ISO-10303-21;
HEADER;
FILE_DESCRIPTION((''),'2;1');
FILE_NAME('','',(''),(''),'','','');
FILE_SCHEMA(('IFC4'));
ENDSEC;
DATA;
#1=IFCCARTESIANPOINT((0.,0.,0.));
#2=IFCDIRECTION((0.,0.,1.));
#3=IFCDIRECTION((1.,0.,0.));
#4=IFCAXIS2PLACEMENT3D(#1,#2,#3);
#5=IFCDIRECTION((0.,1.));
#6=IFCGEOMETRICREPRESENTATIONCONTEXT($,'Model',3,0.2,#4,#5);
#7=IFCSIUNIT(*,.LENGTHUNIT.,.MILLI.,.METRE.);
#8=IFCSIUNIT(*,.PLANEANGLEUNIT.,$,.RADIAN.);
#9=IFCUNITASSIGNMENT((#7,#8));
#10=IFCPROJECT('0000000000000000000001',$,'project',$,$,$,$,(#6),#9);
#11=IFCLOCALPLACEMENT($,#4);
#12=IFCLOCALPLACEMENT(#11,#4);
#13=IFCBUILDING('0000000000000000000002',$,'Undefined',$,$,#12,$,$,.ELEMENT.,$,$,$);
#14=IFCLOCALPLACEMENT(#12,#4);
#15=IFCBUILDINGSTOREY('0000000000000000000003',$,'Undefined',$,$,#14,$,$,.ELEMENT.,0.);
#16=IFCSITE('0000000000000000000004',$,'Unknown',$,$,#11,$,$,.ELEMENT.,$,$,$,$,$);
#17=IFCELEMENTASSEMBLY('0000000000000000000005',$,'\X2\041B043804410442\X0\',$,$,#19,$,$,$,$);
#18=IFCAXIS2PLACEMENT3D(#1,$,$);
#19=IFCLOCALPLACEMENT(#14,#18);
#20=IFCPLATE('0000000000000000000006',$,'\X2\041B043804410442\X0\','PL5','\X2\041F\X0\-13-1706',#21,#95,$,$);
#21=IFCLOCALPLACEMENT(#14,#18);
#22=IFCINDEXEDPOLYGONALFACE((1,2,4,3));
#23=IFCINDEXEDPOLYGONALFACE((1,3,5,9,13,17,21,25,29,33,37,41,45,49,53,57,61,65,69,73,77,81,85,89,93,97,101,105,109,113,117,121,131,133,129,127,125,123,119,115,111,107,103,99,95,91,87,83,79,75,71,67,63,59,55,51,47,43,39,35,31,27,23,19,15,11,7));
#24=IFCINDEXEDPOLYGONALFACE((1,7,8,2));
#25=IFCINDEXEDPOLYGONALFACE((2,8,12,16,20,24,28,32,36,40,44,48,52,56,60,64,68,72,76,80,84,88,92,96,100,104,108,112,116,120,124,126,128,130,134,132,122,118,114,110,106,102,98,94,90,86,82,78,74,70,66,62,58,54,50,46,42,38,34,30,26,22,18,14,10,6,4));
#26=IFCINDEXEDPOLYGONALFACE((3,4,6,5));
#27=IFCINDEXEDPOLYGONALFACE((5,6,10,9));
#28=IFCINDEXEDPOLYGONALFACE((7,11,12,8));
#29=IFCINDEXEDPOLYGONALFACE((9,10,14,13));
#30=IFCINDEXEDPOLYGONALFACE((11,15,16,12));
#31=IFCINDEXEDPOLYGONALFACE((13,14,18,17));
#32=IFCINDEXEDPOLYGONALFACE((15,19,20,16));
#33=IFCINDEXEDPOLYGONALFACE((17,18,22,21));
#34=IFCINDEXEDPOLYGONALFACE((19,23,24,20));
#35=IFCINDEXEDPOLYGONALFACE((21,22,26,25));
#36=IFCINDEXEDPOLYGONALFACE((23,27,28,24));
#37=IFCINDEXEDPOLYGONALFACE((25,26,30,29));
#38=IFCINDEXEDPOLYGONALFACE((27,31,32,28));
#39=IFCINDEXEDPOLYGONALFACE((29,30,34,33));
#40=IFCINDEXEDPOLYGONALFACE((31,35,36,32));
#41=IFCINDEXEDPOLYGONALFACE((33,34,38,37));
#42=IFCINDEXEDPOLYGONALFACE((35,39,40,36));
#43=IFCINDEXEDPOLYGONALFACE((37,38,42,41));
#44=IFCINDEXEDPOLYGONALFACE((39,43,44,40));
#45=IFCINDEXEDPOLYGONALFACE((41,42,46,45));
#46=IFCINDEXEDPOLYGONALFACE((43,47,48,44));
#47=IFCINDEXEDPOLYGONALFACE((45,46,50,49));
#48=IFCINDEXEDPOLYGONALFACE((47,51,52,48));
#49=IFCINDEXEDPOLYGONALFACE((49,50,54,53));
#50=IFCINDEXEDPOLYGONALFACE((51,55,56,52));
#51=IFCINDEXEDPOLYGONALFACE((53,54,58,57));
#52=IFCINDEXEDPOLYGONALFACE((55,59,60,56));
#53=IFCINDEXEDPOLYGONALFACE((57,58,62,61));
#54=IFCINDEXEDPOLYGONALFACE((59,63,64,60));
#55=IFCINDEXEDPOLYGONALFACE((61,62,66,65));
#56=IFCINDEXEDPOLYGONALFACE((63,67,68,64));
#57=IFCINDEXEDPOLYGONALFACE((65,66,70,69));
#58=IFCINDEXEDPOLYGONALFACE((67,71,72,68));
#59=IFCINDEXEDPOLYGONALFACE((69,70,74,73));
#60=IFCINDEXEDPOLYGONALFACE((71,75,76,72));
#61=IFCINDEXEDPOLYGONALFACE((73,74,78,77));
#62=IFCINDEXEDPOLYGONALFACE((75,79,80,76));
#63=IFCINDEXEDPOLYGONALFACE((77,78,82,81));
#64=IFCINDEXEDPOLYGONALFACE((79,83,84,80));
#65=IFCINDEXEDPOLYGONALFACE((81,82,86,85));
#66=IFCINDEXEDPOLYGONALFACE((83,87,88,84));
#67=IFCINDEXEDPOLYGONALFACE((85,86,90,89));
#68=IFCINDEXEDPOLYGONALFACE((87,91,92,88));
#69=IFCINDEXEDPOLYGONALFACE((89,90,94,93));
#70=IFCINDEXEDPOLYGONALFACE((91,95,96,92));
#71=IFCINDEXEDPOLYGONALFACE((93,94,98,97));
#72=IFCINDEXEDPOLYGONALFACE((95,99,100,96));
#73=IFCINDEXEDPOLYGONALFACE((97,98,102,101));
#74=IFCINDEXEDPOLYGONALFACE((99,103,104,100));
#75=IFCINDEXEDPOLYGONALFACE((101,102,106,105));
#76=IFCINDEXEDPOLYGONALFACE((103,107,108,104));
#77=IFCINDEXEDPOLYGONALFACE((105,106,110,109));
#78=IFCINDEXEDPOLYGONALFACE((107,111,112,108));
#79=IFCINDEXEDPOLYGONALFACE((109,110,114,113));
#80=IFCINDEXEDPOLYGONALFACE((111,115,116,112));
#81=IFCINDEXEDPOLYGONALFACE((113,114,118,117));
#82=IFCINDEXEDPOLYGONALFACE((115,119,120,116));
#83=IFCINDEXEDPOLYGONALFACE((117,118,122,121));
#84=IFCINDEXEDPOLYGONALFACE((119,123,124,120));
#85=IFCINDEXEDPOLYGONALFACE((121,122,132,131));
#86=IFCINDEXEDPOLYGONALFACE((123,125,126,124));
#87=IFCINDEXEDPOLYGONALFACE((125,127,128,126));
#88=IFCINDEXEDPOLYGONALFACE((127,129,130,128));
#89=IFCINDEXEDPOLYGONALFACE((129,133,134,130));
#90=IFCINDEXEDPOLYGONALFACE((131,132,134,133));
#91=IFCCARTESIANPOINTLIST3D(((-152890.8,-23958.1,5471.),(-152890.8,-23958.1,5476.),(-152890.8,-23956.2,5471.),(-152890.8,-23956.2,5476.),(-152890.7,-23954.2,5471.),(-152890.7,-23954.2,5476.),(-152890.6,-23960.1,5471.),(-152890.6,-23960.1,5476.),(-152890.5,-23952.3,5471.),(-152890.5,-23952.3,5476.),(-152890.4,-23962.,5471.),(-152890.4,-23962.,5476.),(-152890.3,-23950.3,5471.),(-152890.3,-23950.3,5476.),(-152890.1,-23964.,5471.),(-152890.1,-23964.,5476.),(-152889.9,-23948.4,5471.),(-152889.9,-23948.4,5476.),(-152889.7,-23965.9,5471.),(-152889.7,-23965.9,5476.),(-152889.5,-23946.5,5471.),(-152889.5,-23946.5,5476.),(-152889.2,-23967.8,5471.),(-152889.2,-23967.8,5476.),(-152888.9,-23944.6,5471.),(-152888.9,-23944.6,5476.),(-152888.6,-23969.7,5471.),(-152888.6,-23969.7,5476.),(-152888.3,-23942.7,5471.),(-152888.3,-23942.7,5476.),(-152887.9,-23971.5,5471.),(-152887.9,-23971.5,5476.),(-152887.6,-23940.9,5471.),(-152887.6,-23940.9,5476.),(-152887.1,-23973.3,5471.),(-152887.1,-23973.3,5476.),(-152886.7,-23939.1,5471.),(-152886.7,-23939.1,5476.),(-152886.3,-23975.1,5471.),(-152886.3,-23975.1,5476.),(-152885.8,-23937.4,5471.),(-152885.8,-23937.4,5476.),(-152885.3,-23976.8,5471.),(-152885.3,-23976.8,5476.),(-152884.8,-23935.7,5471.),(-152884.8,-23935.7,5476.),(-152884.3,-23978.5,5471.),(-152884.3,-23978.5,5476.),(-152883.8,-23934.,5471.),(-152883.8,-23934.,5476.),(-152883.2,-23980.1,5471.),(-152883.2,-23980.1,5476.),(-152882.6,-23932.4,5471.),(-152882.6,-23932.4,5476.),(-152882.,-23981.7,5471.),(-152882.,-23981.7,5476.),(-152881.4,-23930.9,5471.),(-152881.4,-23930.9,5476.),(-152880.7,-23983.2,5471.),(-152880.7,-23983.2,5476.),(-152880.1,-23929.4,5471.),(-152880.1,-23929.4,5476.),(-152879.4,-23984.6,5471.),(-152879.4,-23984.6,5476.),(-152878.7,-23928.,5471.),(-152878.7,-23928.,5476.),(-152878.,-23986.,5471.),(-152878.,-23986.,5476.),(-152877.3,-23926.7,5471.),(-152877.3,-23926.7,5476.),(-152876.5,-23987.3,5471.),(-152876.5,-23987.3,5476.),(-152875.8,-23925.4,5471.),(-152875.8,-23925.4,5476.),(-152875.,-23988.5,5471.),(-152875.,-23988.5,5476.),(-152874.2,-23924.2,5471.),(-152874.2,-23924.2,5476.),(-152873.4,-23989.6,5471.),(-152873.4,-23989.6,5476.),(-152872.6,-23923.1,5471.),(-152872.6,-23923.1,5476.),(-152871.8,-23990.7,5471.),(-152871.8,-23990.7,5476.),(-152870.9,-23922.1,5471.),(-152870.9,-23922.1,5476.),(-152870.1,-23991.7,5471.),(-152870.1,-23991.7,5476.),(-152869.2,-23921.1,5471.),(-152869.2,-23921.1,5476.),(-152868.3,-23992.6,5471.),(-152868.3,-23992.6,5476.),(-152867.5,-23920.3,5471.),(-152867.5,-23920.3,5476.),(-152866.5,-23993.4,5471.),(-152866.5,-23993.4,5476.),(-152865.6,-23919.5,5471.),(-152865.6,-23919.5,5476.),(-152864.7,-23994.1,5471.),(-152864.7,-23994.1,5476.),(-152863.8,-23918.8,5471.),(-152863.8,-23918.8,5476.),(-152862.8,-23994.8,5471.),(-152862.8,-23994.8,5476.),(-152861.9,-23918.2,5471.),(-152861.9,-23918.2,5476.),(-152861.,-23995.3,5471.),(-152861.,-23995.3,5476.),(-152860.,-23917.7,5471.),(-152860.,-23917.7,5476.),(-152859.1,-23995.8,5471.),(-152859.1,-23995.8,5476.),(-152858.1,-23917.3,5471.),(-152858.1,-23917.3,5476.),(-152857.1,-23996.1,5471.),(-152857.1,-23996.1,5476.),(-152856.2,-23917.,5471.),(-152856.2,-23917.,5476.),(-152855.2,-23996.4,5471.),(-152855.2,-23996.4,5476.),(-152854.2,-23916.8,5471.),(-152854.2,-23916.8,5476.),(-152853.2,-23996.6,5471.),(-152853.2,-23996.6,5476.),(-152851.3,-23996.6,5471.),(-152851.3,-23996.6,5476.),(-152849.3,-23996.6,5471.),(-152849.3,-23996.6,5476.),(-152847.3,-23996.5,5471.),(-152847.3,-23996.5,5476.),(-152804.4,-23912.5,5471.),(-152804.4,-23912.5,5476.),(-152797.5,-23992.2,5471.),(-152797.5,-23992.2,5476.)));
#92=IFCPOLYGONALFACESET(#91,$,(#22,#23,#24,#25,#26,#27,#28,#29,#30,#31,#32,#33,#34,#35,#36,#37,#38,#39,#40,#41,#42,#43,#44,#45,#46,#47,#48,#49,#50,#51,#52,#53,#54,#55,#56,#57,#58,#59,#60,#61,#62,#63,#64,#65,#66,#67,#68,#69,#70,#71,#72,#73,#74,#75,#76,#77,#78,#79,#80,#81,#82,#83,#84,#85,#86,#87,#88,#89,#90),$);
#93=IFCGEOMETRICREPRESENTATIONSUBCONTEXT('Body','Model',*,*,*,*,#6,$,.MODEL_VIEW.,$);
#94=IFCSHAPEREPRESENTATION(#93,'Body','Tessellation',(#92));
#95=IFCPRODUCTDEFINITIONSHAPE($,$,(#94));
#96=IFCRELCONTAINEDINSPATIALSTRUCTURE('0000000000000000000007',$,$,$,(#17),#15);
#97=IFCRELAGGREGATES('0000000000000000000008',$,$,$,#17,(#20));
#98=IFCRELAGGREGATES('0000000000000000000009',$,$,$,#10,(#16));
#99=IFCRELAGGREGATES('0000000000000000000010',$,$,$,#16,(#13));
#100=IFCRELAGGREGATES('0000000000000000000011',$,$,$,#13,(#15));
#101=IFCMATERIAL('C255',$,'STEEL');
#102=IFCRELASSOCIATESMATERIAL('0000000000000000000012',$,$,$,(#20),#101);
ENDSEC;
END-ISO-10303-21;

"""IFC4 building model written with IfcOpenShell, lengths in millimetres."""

from ifc_helpers import new_model, si_unit, direction, frame, origin_with_axes, place, context, subcontext, project, spatial, line, indexed_curve, outline, extrude, material, element, aggregate, save


model = new_model("IFC4")

# Units and contexts
model_context = context("Model", 3, precision=0.2, world=origin_with_axes(), true_north=direction((0.0, 1.0)))
body_context = subcontext(model_context, "Body", "Model", "MODEL_VIEW")
ifc_project = project(units=[si_unit("LENGTHUNIT", "METRE", prefix="MILLI"), si_unit("PLANEANGLEUNIT", "RADIAN")], contexts=[model_context])

# Site, building, storey
site_placement = place(None, origin_with_axes())
site = spatial("IfcSite", under=ifc_project, at=site_placement, Name="Unknown", CompositionType="ELEMENT")
building_placement = place(site_placement, origin_with_axes())
building = spatial("IfcBuilding", under=site, at=building_placement, Name="Undefined", CompositionType="ELEMENT")
storey_placement = place(building_placement, origin_with_axes())
storey = spatial("IfcBuildingStorey", under=building, at=storey_placement, Name="Undefined", CompositionType="ELEMENT", Elevation=0.0)

# Shared definitions
ifc_material_1 = material(Name="C255", Category="STEEL")

# Element assembly, plate
assembly_1_placement = place(storey_placement, frame((-152790.7, -24041.8, 5431.0), z_axis=(-0.996285, -0.086114, 0.0), x_axis=(0.0, 0.0, 1.0)))
assembly_1 = element("IfcElementAssembly", 1, at=assembly_1_placement, inside=storey, Name="Лист")
plate_1_placement = place(assembly_1_placement, frame((42.5, 50.0, 2.5), z_axis=(1.0, 0.0, 0.0), x_axis=(0.0, 1.0, 0.0)))
plate_1 = element("IfcPlate", 2, at=plate_1_placement, material=ifc_material_1, Name="Лист", Description="PL5", ObjectType="П-13-1706", context=body_context, shape_type="SolidModel", body=[
    extrude(outline(indexed_curve([(0.0, 0.0), (80.0, 0.0), (80.0, 50.0), (80.0, 52.0), (79.8, 53.9), (79.6, 55.9), (79.2, 57.8), (78.8, 59.7), (78.3, 61.6), (77.7, 63.5), (77.0, 65.3), (76.2, 67.1), (75.3, 68.9), (74.3, 70.6), (73.3, 72.2), (72.1, 73.8), (70.9, 75.4), (69.6, 76.9), (68.3, 78.3), (66.9, 79.6), (65.4, 80.9), (63.8, 82.1), (62.2, 83.3), (60.6, 84.3), (58.9, 85.3), (57.1, 86.2), (55.3, 87.0), (53.5, 87.7), (51.6, 88.3), (49.7, 88.8), (47.8, 89.2), (45.9, 89.6), (43.9, 89.8), (42.0, 90.0), (40.0, 90.0), (40.0, 90.0), (38.0, 90.0), (36.1, 89.8), (34.1, 89.6), (32.2, 89.2), (30.3, 88.8), (28.4, 88.3), (26.5, 87.7), (24.7, 87.0), (22.9, 86.2), (21.1, 85.3), (19.4, 84.3), (17.8, 83.3), (16.2, 82.1), (14.6, 80.9), (13.1, 79.6), (11.7, 78.3), (10.4, 76.9), (9.1, 75.4), (7.9, 73.8), (6.7, 72.2), (5.7, 70.6), (4.7, 68.9), (3.8, 67.1), (3.0, 65.3), (2.3, 63.5), (1.7, 61.6), (1.2, 59.7), (0.8, 57.8), (0.4, 55.9), (0.2, 53.9), (0.0, 52.0), (0.0, 50.0)], segments=[line(1, 2, 3, 4, 5, 6, 7, 8, 9, 10, 11, 12, 13, 14, 15, 16, 17, 18, 19, 20, 21, 22, 23, 24, 25, 26, 27, 28, 29, 30, 31, 32, 33, 34, 35, 36, 37, 38, 39, 40, 41, 42, 43, 44, 45, 46, 47, 48, 49, 50, 51, 52, 53, 54, 55, 56, 57, 58, 59, 60, 61, 62, 63, 64, 65, 66, 67, 68, 1)])), frame((0.0, 0.0, 2.5), z_axis=(0.0, 0.0, 1.0), x_axis=(1.0, 0.0, 0.0)), (0.0, 0.0, -1.0), 5.0),
])
aggregate(assembly_1, [plate_1])

save(model, "model.ifc")
